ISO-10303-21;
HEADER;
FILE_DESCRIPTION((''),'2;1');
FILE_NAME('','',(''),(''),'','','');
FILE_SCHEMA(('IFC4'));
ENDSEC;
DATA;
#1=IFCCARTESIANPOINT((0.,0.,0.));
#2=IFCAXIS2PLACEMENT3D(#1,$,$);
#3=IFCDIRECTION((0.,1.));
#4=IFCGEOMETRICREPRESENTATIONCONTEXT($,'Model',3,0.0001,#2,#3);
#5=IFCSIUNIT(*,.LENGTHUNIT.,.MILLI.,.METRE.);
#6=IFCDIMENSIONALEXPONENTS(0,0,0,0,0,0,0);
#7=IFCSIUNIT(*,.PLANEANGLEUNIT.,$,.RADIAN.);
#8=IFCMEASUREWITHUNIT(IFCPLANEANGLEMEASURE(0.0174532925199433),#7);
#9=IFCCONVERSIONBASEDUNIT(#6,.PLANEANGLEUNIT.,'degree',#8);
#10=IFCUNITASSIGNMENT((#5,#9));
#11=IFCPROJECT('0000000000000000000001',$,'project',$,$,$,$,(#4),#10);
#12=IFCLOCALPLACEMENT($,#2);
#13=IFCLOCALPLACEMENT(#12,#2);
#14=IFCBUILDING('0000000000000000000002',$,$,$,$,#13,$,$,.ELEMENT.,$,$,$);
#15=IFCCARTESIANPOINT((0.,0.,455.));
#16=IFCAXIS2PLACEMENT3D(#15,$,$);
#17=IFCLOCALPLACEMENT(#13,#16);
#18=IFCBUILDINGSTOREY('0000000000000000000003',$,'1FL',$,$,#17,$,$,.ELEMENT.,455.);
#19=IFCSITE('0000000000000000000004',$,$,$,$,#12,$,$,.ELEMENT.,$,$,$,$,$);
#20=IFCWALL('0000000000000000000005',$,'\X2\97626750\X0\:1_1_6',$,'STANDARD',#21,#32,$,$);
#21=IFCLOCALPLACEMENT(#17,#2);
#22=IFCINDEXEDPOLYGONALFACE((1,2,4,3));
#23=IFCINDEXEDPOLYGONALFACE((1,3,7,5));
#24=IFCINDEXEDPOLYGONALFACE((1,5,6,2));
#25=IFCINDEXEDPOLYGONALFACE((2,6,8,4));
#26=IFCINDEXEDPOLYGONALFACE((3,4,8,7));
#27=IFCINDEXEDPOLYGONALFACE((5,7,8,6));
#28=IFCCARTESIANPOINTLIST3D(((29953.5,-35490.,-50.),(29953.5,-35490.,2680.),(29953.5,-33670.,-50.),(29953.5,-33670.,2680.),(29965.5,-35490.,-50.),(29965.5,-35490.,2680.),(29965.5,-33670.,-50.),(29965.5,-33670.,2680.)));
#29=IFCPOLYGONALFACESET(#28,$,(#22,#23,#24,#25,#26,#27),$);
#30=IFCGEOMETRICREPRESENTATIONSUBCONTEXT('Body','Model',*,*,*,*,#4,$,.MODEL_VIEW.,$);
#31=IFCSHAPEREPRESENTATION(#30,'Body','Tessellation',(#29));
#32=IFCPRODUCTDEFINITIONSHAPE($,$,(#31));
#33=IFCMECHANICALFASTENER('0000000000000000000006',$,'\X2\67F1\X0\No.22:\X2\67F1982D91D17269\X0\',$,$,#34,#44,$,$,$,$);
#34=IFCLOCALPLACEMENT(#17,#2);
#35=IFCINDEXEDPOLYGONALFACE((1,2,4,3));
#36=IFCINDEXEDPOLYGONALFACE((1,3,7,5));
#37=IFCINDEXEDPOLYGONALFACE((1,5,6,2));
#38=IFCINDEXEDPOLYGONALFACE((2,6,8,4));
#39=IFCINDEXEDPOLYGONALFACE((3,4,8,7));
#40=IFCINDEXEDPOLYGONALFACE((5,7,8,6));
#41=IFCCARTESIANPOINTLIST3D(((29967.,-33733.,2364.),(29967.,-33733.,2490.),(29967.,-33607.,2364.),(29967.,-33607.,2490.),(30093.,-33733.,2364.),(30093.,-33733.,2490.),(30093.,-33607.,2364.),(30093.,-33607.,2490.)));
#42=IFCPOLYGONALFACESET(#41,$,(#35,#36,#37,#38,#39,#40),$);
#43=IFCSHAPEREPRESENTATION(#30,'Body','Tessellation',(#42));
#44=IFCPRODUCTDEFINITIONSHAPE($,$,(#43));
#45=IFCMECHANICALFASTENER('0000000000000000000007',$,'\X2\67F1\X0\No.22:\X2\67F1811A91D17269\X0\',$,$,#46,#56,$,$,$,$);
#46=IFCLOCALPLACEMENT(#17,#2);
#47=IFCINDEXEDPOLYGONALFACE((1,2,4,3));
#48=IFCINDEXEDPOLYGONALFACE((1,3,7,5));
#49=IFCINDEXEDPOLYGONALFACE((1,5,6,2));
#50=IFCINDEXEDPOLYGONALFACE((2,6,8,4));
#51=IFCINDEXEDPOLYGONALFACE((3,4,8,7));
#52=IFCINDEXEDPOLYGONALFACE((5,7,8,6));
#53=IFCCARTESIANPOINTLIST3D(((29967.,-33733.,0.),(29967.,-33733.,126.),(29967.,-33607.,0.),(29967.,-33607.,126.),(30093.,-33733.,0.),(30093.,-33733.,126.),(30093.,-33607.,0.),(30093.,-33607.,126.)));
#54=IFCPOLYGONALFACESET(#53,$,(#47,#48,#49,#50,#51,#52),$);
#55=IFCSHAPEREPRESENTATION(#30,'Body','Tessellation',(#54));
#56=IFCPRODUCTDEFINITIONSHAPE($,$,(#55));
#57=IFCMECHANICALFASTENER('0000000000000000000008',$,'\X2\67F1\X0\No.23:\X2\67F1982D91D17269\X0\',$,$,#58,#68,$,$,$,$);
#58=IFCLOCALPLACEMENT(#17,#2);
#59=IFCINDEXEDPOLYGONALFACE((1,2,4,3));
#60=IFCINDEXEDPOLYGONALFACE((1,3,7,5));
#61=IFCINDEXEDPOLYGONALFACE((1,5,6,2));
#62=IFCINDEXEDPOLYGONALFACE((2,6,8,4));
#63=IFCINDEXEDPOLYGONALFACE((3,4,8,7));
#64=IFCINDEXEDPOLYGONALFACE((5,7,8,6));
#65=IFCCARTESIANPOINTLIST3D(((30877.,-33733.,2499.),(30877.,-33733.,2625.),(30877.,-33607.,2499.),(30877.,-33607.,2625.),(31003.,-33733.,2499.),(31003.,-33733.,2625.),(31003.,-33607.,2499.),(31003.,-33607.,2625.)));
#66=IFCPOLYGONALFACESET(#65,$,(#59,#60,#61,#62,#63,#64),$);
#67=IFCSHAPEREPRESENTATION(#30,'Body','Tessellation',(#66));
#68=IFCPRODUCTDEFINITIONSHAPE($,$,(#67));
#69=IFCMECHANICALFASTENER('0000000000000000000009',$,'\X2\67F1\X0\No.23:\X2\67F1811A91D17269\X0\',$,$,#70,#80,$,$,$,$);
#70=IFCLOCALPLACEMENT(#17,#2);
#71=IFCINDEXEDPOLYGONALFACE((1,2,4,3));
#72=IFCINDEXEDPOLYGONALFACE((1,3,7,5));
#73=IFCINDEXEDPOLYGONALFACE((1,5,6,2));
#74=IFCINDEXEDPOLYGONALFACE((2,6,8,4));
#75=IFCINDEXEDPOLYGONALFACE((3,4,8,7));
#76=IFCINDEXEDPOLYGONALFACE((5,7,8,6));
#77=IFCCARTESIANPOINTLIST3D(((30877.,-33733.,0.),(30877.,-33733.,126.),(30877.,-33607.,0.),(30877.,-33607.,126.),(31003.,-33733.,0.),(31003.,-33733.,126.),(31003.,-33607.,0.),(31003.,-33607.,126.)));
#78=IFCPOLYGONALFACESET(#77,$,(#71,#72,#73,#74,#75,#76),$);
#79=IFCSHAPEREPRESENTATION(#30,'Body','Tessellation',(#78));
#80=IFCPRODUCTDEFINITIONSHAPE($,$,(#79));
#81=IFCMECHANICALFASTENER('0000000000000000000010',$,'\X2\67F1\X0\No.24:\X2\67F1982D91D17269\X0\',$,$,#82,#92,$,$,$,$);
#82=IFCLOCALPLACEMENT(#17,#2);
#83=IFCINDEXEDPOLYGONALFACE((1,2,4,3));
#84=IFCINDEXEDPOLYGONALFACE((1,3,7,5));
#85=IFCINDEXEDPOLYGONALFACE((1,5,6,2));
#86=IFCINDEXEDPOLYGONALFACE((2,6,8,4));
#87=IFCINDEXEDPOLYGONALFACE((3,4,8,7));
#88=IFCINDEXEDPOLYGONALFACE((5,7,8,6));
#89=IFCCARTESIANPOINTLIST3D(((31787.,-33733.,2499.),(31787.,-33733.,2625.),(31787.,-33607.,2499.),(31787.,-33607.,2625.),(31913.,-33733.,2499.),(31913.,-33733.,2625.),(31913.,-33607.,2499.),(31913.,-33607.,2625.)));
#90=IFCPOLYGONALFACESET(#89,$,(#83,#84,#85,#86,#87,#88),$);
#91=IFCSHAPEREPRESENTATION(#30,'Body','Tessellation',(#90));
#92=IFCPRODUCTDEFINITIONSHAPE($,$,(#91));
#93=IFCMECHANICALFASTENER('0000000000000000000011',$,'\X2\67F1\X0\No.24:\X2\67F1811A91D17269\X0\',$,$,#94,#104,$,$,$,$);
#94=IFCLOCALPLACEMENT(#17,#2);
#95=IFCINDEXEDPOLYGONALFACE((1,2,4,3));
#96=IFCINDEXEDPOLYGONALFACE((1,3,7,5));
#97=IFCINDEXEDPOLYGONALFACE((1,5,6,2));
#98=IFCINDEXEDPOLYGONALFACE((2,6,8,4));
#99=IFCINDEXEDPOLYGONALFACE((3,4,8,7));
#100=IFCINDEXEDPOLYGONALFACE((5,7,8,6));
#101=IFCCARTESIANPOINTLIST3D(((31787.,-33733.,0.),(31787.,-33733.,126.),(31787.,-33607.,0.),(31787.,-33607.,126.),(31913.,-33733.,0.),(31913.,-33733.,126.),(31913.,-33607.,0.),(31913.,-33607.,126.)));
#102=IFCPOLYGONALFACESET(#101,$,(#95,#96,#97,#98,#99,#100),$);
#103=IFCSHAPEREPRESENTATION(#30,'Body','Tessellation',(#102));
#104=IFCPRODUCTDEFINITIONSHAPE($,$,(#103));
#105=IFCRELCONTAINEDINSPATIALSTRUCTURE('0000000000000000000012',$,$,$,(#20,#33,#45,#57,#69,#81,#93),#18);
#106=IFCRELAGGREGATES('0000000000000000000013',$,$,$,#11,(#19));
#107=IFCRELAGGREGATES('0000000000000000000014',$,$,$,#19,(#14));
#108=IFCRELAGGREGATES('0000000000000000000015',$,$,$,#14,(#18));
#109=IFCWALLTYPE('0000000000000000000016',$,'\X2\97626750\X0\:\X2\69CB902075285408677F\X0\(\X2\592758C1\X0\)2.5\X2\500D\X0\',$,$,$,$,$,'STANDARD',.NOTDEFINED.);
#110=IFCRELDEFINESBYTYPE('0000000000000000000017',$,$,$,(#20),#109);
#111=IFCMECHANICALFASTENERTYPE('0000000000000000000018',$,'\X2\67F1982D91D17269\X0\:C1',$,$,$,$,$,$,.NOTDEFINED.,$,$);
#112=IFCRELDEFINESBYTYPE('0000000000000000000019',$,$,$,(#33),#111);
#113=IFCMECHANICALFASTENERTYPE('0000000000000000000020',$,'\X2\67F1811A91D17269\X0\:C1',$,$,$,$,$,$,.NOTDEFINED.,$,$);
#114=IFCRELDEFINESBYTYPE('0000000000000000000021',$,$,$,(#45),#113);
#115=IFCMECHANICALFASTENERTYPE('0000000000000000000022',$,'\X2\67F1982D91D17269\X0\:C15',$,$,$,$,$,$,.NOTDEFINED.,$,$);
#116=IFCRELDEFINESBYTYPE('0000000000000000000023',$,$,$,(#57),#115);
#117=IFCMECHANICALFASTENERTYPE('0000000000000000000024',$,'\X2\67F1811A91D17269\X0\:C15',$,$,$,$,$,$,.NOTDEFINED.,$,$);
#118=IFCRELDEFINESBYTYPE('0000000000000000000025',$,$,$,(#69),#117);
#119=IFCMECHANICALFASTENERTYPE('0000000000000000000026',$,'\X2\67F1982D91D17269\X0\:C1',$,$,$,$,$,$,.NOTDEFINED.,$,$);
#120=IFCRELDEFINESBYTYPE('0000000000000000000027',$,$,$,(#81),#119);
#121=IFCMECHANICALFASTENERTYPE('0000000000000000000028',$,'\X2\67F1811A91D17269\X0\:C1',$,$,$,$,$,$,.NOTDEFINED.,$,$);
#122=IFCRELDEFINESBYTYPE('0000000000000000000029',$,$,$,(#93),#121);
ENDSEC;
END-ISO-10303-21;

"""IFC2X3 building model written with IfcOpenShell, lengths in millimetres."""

from ifc_helpers import new_model, entity, si_unit, converted_unit, direction, frame, origin, origin_with_axes, origin_2d, place, context, subcontext, project, spatial, polyline, rectangle, outline, extrude, type_object, element, save


model = new_model("IFC2X3")

# Units and contexts
model_context = context("Model", 3, precision=0.0001, world=origin(), true_north=direction((0.0, 1.0)))
body_context = subcontext(model_context, "Body", "Model", "MODEL_VIEW")
ifc_project = project(units=[si_unit("LENGTHUNIT", "METRE", prefix="MILLI"), converted_unit("PLANEANGLEUNIT", "degree", entity("IfcPlaneAngleMeasure", 0.0174532925199433), si_unit("PLANEANGLEUNIT", "RADIAN"), dimensions=[0, 0, 0, 0, 0, 0, 0])], contexts=[model_context])

# Site, building, storey
site_placement = place(None, origin())
site = spatial("IfcSite", under=ifc_project, at=site_placement, CompositionType="ELEMENT")
building_placement = place(site_placement, origin())
building = spatial("IfcBuilding", under=site, at=building_placement, CompositionType="ELEMENT")
storey_placement = place(building_placement, frame((0.0, 0.0, 455.0)))
storey = spatial("IfcBuildingStorey", under=building, at=storey_placement, Name="1FL", CompositionType="ELEMENT", Elevation=455.0)

# Wall
wall_type_1 = type_object("IfcWallType", Name="面材:構造用合板(大壁)2.5倍", ElementType="STANDARD", PredefinedType="NOTDEFINED")
wall_1_placement = place(storey_placement, frame((29965.5, -34580.0, -50.0), z_axis=(-1.0, 0.0, 0.0), x_axis=(0.0, -1.0, 0.0)))
element("IfcWall", 1, at=wall_1_placement, inside=storey, type_object=wall_type_1, Name="面材:1_1_6", ObjectType="STANDARD", context=body_context, shape_type="SweptSolid", body=[
    extrude(outline(polyline([(910.0, 0.0, 0.0), (-910.0, 0.0, 0.0), (-910.0, 2730.0, 0.0), (910.0, 2730.0, 0.0), (910.0, 0.0, 0.0)])), origin_with_axes(), (0.0, 0.0, 1.0), 12.0),
])

# Mechanical fasteners
mechanical_fastener_type_1 = type_object("IfcMechanicalFastenerType", Name="柱頭金物:C1")
mechanical_fastener_1_placement = place(storey_placement, frame((30030.0, -33670.0, 2364.0)))
element("IfcMechanicalFastener", 2, at=mechanical_fastener_1_placement, inside=storey, type_object=mechanical_fastener_type_1, Name="柱No.22:柱頭金物", context=body_context, shape_type="SweptSolid", body=[
    extrude(rectangle(XDim=126.0, YDim=126.0, at=origin_2d()), origin_with_axes(), (0.0, 0.0, 1.0), 126.0),
])
mechanical_fastener_type_2 = type_object("IfcMechanicalFastenerType", Name="柱脚金物:C1")
mechanical_fastener_2_placement = place(storey_placement, frame((30030.0, -33670.0, 0.0)))
element("IfcMechanicalFastener", 3, at=mechanical_fastener_2_placement, inside=storey, type_object=mechanical_fastener_type_2, Name="柱No.22:柱脚金物", context=body_context, shape_type="SweptSolid", body=[
    extrude(rectangle(XDim=126.0, YDim=126.0, at=origin_2d()), origin_with_axes(), (0.0, 0.0, 1.0), 126.0),
])
mechanical_fastener_type_3 = type_object("IfcMechanicalFastenerType", Name="柱頭金物:C15")
mechanical_fastener_3_placement = place(storey_placement, frame((30940.0, -33670.0, 2499.0)))
element("IfcMechanicalFastener", 4, at=mechanical_fastener_3_placement, inside=storey, type_object=mechanical_fastener_type_3, Name="柱No.23:柱頭金物", context=body_context, shape_type="SweptSolid", body=[
    extrude(rectangle(XDim=126.0, YDim=126.0, at=origin_2d()), origin_with_axes(), (0.0, 0.0, 1.0), 126.0),
])
mechanical_fastener_type_4 = type_object("IfcMechanicalFastenerType", Name="柱脚金物:C15")
mechanical_fastener_4_placement = place(storey_placement, frame((30940.0, -33670.0, 0.0)))
element("IfcMechanicalFastener", 5, at=mechanical_fastener_4_placement, inside=storey, type_object=mechanical_fastener_type_4, Name="柱No.23:柱脚金物", context=body_context, shape_type="SweptSolid", body=[
    extrude(rectangle(XDim=126.0, YDim=126.0, at=origin_2d()), origin_with_axes(), (0.0, 0.0, 1.0), 126.0),
])
mechanical_fastener_type_5 = type_object("IfcMechanicalFastenerType", Name="柱頭金物:C1")
mechanical_fastener_5_placement = place(storey_placement, frame((31850.0, -33670.0, 2499.0)))
element("IfcMechanicalFastener", 6, at=mechanical_fastener_5_placement, inside=storey, type_object=mechanical_fastener_type_5, Name="柱No.24:柱頭金物", context=body_context, shape_type="SweptSolid", body=[
    extrude(rectangle(XDim=126.0, YDim=126.0, at=origin_2d()), origin_with_axes(), (0.0, 0.0, 1.0), 126.0),
])
mechanical_fastener_type_6 = type_object("IfcMechanicalFastenerType", Name="柱脚金物:C1")
mechanical_fastener_6_placement = place(storey_placement, frame((31850.0, -33670.0, 0.0)))
element("IfcMechanicalFastener", 7, at=mechanical_fastener_6_placement, inside=storey, type_object=mechanical_fastener_type_6, Name="柱No.24:柱脚金物", context=body_context, shape_type="SweptSolid", body=[
    extrude(rectangle(XDim=126.0, YDim=126.0, at=origin_2d()), origin_with_axes(), (0.0, 0.0, 1.0), 126.0),
])

save(model, "model.ifc")
